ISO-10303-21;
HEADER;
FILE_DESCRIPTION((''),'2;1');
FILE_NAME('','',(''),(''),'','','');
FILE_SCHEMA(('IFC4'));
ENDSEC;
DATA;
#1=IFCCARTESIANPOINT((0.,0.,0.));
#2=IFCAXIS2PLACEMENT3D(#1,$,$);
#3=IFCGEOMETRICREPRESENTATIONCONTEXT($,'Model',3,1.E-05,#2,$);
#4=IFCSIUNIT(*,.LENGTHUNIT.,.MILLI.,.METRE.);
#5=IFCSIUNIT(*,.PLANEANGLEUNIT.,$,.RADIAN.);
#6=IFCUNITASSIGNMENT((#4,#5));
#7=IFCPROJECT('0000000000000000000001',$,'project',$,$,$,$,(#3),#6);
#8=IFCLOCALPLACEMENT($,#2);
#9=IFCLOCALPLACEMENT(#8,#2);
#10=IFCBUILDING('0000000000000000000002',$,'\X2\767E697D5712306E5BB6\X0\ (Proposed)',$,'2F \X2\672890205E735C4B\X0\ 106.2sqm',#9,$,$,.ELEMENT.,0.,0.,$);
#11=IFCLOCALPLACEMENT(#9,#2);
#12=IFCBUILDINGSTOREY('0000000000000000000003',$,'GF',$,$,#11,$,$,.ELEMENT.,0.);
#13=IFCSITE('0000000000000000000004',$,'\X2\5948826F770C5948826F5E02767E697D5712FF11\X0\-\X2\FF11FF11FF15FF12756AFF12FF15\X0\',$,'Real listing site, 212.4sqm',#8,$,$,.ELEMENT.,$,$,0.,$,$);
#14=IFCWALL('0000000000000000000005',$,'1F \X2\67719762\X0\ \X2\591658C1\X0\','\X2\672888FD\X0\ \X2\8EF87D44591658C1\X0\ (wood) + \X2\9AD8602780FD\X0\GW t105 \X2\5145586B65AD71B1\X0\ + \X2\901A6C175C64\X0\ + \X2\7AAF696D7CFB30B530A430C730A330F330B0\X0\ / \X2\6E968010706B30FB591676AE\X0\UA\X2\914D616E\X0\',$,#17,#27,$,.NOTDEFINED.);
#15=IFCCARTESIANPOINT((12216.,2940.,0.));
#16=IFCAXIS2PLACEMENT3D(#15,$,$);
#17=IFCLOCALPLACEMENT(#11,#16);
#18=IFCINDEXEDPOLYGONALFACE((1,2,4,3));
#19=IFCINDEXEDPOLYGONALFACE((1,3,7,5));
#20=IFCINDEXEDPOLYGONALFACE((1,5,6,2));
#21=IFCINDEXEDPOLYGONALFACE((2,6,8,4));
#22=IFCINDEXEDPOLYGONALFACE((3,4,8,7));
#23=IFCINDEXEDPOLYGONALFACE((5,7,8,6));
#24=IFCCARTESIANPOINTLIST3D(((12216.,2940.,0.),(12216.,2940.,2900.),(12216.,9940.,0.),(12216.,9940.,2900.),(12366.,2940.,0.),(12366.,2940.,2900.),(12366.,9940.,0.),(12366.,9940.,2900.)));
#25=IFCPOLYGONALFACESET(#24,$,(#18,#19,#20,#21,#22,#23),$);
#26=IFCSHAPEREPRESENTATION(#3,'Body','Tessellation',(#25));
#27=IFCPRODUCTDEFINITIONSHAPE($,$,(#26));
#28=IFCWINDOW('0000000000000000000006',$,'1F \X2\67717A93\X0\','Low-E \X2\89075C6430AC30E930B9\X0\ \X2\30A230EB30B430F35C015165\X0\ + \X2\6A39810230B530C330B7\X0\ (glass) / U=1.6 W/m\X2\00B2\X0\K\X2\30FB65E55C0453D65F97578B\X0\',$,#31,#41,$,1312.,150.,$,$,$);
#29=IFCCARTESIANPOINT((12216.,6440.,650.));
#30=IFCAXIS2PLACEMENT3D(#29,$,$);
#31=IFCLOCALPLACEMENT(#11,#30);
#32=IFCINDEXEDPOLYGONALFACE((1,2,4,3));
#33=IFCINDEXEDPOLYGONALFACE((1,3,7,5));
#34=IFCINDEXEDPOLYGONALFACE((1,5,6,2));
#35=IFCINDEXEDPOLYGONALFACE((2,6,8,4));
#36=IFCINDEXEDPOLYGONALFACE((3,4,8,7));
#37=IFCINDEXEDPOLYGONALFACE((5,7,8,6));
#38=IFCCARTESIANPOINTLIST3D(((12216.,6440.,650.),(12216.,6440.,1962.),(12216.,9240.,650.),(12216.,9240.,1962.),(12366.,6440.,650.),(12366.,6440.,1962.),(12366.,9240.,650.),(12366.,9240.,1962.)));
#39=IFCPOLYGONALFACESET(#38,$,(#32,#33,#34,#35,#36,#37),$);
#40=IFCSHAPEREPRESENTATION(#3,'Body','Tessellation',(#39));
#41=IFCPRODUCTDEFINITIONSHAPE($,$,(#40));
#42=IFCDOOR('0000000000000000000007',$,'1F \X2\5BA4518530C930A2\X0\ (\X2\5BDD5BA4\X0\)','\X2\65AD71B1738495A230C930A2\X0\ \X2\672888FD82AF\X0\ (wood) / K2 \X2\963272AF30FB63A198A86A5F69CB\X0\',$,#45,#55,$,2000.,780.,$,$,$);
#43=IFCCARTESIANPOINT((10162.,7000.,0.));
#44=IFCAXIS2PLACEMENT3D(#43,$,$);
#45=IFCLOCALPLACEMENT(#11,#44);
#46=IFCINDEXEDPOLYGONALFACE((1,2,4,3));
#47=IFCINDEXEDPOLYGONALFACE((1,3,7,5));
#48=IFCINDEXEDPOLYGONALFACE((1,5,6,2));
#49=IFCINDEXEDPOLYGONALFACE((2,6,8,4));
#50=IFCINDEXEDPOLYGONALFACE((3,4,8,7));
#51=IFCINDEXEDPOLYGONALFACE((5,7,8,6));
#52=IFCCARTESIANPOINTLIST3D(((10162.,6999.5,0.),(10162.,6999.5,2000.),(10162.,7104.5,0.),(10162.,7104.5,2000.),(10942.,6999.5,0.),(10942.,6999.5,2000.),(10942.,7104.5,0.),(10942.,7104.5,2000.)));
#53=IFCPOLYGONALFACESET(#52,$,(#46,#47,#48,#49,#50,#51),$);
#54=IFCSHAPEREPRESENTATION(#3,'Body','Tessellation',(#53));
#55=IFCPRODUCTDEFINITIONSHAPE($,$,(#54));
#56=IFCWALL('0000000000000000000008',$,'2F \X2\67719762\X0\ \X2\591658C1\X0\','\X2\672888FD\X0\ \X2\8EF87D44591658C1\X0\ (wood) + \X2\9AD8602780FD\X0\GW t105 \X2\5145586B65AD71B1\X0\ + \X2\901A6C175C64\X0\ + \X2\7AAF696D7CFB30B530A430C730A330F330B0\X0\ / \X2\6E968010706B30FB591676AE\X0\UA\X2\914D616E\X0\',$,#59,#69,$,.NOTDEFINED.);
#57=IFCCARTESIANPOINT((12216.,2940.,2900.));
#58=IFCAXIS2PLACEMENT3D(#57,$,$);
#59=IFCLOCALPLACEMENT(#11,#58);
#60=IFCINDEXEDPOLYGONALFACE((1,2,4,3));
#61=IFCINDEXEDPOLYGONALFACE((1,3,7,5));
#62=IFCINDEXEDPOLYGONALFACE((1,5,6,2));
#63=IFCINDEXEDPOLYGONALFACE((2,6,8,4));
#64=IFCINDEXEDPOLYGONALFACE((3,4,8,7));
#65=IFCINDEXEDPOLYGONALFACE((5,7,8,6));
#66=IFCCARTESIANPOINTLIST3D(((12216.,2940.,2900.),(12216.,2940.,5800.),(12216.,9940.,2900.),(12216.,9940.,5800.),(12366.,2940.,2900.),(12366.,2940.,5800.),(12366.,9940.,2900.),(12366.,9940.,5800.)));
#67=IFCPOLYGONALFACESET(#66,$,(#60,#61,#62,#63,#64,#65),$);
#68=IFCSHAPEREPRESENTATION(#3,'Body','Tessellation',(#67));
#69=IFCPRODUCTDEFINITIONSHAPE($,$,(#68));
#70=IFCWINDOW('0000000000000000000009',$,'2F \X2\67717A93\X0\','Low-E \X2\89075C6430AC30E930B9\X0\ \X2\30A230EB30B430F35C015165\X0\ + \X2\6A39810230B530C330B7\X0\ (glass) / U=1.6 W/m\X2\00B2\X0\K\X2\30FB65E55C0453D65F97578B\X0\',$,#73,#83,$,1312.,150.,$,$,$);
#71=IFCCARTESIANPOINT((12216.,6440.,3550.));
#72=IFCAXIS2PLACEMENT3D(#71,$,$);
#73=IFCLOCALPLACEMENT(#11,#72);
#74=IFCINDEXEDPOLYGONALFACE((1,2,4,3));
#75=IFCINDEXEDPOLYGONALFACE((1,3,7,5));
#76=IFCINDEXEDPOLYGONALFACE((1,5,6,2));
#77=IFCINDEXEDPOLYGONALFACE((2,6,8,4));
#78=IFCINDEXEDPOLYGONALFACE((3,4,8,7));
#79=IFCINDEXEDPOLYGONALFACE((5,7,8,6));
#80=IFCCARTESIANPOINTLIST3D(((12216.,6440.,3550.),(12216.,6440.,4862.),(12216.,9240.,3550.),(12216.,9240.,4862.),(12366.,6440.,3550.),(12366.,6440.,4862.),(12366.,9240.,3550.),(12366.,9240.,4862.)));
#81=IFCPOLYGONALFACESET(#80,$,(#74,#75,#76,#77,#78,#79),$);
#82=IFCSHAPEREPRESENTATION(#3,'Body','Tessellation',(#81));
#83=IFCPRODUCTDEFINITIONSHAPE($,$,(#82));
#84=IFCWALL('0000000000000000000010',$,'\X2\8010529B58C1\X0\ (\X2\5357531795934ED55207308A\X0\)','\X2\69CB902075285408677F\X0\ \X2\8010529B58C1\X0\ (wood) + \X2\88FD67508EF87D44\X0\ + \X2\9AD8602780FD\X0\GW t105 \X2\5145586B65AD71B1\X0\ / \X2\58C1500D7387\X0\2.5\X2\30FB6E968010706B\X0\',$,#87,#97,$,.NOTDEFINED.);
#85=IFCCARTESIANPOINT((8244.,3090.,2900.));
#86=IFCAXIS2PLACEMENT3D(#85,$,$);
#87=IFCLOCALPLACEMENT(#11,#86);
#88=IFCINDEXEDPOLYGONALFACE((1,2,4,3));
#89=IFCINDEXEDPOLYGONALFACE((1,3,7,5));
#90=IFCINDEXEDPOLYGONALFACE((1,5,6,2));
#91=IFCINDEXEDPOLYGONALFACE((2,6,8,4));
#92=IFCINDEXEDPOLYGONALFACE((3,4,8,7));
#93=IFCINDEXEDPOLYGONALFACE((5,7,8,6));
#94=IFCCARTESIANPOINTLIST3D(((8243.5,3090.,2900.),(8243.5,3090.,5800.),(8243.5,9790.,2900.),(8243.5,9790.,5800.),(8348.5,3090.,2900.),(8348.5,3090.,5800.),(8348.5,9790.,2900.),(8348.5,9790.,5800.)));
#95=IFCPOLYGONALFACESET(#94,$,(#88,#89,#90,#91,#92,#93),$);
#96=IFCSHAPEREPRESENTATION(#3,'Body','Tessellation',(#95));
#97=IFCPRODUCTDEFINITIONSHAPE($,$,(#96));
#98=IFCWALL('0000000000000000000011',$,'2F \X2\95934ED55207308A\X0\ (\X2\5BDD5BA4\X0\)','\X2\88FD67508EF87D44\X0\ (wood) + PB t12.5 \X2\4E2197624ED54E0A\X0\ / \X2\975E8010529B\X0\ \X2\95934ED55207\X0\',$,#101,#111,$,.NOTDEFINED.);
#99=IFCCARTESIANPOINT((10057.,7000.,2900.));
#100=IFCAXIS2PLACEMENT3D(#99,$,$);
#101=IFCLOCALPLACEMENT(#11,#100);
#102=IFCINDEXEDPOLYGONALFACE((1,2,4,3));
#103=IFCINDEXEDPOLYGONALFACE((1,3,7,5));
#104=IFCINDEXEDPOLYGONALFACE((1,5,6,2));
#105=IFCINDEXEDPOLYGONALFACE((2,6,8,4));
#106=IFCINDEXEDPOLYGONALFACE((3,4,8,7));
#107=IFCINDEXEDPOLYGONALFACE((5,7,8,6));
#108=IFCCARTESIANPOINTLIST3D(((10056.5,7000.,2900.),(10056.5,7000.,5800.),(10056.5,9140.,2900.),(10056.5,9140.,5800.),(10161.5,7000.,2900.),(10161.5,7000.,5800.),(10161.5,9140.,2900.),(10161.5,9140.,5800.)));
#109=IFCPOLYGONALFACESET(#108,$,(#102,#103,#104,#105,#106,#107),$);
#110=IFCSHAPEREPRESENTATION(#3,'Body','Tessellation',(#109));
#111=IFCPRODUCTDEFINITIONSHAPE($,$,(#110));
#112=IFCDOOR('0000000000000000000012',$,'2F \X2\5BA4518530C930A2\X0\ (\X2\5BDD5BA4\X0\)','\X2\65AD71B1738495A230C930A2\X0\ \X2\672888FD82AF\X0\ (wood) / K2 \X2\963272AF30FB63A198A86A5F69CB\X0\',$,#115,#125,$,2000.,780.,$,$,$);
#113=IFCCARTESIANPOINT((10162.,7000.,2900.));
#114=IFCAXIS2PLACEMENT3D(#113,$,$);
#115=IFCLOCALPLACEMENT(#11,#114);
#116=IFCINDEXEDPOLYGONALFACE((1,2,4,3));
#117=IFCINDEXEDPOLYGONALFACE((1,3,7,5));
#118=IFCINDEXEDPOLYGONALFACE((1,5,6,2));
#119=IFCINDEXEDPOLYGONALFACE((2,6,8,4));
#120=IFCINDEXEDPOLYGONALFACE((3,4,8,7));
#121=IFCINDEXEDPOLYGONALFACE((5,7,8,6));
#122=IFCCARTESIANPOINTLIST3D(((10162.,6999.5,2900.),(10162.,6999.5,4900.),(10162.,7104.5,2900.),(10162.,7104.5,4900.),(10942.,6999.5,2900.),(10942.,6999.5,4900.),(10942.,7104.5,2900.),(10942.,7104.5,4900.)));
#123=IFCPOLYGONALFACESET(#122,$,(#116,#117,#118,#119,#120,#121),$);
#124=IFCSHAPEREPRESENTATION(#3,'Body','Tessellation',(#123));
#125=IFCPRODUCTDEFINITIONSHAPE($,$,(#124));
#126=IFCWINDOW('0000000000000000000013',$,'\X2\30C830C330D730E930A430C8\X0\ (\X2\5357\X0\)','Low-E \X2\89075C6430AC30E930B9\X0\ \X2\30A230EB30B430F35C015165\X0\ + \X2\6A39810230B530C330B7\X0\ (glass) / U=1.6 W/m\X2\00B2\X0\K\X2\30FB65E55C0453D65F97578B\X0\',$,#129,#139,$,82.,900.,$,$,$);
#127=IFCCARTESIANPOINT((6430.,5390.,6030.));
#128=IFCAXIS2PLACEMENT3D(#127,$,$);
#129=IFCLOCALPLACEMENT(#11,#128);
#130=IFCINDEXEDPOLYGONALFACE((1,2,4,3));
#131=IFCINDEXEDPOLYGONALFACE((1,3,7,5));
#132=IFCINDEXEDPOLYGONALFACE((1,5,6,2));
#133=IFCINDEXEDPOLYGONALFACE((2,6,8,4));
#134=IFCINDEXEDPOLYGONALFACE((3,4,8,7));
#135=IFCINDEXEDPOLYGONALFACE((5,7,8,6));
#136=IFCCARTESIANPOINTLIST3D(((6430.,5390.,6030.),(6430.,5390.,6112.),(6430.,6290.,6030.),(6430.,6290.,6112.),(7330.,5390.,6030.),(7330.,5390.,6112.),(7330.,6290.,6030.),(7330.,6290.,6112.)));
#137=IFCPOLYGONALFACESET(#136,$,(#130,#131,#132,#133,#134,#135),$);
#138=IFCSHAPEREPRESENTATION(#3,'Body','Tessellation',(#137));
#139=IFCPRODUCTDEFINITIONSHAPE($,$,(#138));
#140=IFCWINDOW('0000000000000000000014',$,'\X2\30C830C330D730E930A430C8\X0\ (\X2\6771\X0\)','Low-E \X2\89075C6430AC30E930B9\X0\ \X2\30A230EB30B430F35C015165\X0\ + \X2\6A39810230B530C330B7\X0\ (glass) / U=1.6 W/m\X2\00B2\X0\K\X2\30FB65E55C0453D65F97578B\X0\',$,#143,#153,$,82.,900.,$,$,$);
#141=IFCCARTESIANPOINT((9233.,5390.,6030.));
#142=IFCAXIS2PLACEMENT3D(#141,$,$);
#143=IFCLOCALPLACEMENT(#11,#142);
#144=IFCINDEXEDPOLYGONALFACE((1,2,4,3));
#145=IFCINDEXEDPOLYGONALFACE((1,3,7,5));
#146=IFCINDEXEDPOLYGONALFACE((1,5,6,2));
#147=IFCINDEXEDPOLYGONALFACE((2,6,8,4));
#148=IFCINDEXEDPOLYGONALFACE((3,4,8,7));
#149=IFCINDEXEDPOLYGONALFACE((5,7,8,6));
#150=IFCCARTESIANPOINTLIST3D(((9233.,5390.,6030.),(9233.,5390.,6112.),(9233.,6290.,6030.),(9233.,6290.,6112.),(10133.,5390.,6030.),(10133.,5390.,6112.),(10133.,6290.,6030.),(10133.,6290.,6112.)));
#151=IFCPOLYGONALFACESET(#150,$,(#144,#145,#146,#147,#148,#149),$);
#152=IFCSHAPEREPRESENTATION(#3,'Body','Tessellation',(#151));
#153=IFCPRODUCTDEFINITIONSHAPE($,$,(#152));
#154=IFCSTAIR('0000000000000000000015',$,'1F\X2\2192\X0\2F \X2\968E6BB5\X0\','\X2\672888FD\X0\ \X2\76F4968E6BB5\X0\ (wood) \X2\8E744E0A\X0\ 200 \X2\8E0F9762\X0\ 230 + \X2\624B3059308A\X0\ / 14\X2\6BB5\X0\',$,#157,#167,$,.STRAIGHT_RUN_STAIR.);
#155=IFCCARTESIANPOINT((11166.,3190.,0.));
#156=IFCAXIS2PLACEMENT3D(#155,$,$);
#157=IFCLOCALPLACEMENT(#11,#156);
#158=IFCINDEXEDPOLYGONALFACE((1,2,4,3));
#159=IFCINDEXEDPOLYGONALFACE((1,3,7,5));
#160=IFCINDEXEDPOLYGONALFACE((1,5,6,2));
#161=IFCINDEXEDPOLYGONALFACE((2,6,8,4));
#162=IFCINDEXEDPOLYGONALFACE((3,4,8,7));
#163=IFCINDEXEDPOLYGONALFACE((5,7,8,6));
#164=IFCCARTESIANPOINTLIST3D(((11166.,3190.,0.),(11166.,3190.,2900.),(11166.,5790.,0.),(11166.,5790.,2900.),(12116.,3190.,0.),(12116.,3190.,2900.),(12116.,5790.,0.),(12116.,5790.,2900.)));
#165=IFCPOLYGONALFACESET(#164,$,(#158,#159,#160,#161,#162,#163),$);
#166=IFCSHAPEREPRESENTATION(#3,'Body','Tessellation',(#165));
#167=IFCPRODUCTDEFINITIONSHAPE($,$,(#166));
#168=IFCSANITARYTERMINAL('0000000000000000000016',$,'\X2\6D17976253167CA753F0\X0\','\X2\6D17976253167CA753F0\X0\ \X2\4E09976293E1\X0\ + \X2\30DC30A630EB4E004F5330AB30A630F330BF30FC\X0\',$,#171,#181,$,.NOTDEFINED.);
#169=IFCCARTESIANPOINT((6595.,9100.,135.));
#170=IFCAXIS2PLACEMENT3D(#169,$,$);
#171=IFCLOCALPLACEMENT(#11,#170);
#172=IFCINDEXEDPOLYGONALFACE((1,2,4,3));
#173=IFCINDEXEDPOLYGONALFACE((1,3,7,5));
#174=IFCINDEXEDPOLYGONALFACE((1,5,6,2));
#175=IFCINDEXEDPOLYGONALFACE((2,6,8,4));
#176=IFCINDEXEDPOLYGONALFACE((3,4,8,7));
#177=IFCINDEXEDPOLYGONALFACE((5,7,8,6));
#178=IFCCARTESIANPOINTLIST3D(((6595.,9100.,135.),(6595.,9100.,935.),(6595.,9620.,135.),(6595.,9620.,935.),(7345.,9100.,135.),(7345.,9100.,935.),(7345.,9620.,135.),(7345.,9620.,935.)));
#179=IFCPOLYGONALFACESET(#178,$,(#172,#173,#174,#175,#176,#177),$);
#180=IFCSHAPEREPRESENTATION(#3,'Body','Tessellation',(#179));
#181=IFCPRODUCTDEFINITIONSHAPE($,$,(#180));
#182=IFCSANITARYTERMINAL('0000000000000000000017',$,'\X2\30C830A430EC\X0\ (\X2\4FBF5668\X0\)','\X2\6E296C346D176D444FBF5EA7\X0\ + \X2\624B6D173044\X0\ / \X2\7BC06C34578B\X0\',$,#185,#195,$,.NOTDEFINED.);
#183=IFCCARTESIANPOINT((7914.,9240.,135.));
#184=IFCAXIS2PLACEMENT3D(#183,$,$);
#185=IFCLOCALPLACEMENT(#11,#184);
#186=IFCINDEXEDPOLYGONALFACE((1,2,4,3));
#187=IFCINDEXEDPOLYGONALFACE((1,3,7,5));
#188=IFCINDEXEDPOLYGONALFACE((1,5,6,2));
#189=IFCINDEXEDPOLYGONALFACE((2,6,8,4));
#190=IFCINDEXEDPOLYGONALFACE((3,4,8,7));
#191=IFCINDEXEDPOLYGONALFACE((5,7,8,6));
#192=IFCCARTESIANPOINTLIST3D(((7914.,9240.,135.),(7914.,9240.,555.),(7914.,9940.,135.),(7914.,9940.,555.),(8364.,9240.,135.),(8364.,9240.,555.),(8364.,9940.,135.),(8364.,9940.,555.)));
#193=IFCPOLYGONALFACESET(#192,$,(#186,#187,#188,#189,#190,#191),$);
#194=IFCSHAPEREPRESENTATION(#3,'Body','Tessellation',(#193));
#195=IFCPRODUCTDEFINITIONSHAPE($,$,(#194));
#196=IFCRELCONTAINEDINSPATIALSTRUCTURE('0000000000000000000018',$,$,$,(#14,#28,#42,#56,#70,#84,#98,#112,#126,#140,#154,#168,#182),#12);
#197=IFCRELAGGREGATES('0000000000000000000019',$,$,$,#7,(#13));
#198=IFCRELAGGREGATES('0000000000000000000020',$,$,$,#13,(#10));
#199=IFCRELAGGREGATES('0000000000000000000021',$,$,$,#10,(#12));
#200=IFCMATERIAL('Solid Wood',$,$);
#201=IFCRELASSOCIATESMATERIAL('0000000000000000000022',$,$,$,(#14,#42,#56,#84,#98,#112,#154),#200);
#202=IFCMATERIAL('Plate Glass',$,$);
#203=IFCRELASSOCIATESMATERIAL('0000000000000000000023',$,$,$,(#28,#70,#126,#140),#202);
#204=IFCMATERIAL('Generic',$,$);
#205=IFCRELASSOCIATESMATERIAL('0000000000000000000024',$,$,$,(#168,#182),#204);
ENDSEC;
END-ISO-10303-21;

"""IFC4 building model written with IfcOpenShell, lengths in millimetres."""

from ifc_helpers import new_model, si_unit, frame, frame_2d, origin, place, context, project, spatial, rectangle, extrude, material, element, fill, save


model = new_model("IFC4")

# Units and contexts
model_context = context("Model", 3, precision=1e-05, world=origin())
ifc_project = project(units=[si_unit("LENGTHUNIT", "METRE", prefix="MILLI"), si_unit("PLANEANGLEUNIT", "RADIAN")], contexts=[model_context])

# Site, building, storey
site_placement = place(None, origin())
site = spatial("IfcSite", under=ifc_project, at=site_placement, Name="奈良県奈良市百楽園１-１１５２番２５", ObjectType="Real listing site, 212.4sqm", CompositionType="ELEMENT", RefElevation=0.0)
building_placement = place(site_placement, origin())
building = spatial("IfcBuilding", under=site, at=building_placement, Name="百楽園の家 (Proposed)", ObjectType="2F 木造平屋 106.2sqm", CompositionType="ELEMENT", ElevationOfRefHeight=0.0, ElevationOfTerrain=0.0)
storey_placement = place(building_placement, origin())
storey = spatial("IfcBuildingStorey", under=building, at=storey_placement, Name="GF", CompositionType="ELEMENT", Elevation=0.0)

# Wall, opening, window
ifc_material_1 = material(Name="Solid Wood")
wall_1_placement = place(storey_placement, frame((12216.0, 2940.0, 0.0)))
wall_1 = element("IfcWall", 1, at=wall_1_placement, inside=storey, material=ifc_material_1, Name="1F 東面 外壁", Description="木製 軸組外壁 (wood) + 高性能GW t105 充填断熱 + 通気層 + 窯業系サイディング / 準耐火・外皮UA配慮", PredefinedType="NOTDEFINED", context=model_context, shape_type="SweptSolid", body=[
    extrude(rectangle(XDim=150.0, YDim=7000.0, at=frame_2d((75.0, 3500.0))), frame((12216.0, 2940.0, 0.0)), (0.0, 0.0, 1.0), 2900.0),
])
opening_1_placement = place(storey_placement, frame((12216.0, 6440.0, 650.0)))
opening_1 = element("IfcOpeningElement", 2, at=opening_1_placement, cuts=wall_1, PredefinedType="NOTDEFINED", context=model_context, shape_type="SweptSolid", body=[
    extrude(rectangle(XDim=150.0, YDim=2800.0, at=frame_2d((75.0, 1400.0))), frame((12216.0, 6440.0, 650.0)), (0.0, 0.0, 1.0), 1312.0),
])
ifc_material_2 = material(Name="Plate Glass")
window_1_placement = place(storey_placement, frame((12216.0, 6440.0, 650.0)))
window_1 = element("IfcWindow", 3, at=window_1_placement, inside=storey, material=ifc_material_2, Name="1F 東窓", Description="Low-E 複層ガラス アルゴン封入 + 樹脂サッシ (glass) / U=1.6 W/m²K・日射取得型", OverallHeight=1312.0, OverallWidth=150.0, context=model_context, shape_type="SweptSolid", body=[
    extrude(rectangle(XDim=150.0, YDim=2800.0, at=frame_2d((75.0, 1400.0))), frame((12216.0, 6440.0, 650.0)), (0.0, 0.0, 1.0), 1312.0),
])
fill(opening_1, window_1)

# Door
door_1_placement = place(storey_placement, frame((10162.0, 7000.0, 0.0)))
element("IfcDoor", 4, at=door_1_placement, inside=storey, material=ifc_material_1, Name="1F 室内ドア (寝室)", Description="断熱玄関ドア 木製芯 (wood) / K2 防犯・採風機構", OverallHeight=2000.0, OverallWidth=780.0, context=model_context, shape_type="SweptSolid", body=[
    extrude(rectangle(XDim=780.0, YDim=105.0, at=frame_2d((390.0, 52.0))), frame((10162.0, 7000.0, 0.0)), (0.0, 0.0, 1.0), 2000.0),
])

# Wall, opening, window
wall_2_placement = place(storey_placement, frame((12216.0, 2940.0, 2900.0)))
wall_2 = element("IfcWall", 5, at=wall_2_placement, inside=storey, material=ifc_material_1, Name="2F 東面 外壁", Description="木製 軸組外壁 (wood) + 高性能GW t105 充填断熱 + 通気層 + 窯業系サイディング / 準耐火・外皮UA配慮", PredefinedType="NOTDEFINED", context=model_context, shape_type="SweptSolid", body=[
    extrude(rectangle(XDim=150.0, YDim=7000.0, at=frame_2d((75.0, 3500.0))), frame((12216.0, 2940.0, 2900.0)), (0.0, 0.0, 1.0), 2900.0),
])
opening_2_placement = place(storey_placement, frame((12216.0, 6440.0, 3550.0)))
opening_2 = element("IfcOpeningElement", 6, at=opening_2_placement, cuts=wall_2, PredefinedType="NOTDEFINED", context=model_context, shape_type="SweptSolid", body=[
    extrude(rectangle(XDim=150.0, YDim=2800.0, at=frame_2d((75.0, 1400.0))), frame((12216.0, 6440.0, 3550.0)), (0.0, 0.0, 1.0), 1312.0),
])
window_2_placement = place(storey_placement, frame((12216.0, 6440.0, 3550.0)))
window_2 = element("IfcWindow", 7, at=window_2_placement, inside=storey, material=ifc_material_2, Name="2F 東窓", Description="Low-E 複層ガラス アルゴン封入 + 樹脂サッシ (glass) / U=1.6 W/m²K・日射取得型", OverallHeight=1312.0, OverallWidth=150.0, context=model_context, shape_type="SweptSolid", body=[
    extrude(rectangle(XDim=150.0, YDim=2800.0, at=frame_2d((75.0, 1400.0))), frame((12216.0, 6440.0, 3550.0)), (0.0, 0.0, 1.0), 1312.0),
])
fill(opening_2, window_2)

# Walls
wall_3_placement = place(storey_placement, frame((8244.0, 3090.0, 2900.0)))
element("IfcWall", 8, at=wall_3_placement, inside=storey, material=ifc_material_1, Name="耐力壁 (南北間仕切り)", Description="構造用合板 耐力壁 (wood) + 製材軸組 + 高性能GW t105 充填断熱 / 壁倍率2.5・準耐火", PredefinedType="NOTDEFINED", context=model_context, shape_type="SweptSolid", body=[
    extrude(rectangle(XDim=105.0, YDim=6700.0, at=frame_2d((52.0, 3350.0))), frame((8244.0, 3090.0, 2900.0)), (0.0, 0.0, 1.0), 2900.0),
])
wall_4_placement = place(storey_placement, frame((10057.0, 7000.0, 2900.0)))
element("IfcWall", 9, at=wall_4_placement, inside=storey, material=ifc_material_1, Name="2F 間仕切り (寝室)", Description="製材軸組 (wood) + PB t12.5 両面仕上 / 非耐力 間仕切", PredefinedType="NOTDEFINED", context=model_context, shape_type="SweptSolid", body=[
    extrude(rectangle(XDim=105.0, YDim=2140.0, at=frame_2d((52.0, 1070.0))), frame((10057.0, 7000.0, 2900.0)), (0.0, 0.0, 1.0), 2900.0),
])

# Door
door_2_placement = place(storey_placement, frame((10162.0, 7000.0, 2900.0)))
element("IfcDoor", 10, at=door_2_placement, inside=storey, material=ifc_material_1, Name="2F 室内ドア (寝室)", Description="断熱玄関ドア 木製芯 (wood) / K2 防犯・採風機構", OverallHeight=2000.0, OverallWidth=780.0, context=model_context, shape_type="SweptSolid", body=[
    extrude(rectangle(XDim=780.0, YDim=105.0, at=frame_2d((390.0, 52.0))), frame((10162.0, 7000.0, 2900.0)), (0.0, 0.0, 1.0), 2000.0),
])

# Windows
window_3_placement = place(storey_placement, frame((6430.0, 5390.0, 6030.0)))
element("IfcWindow", 11, at=window_3_placement, inside=storey, material=ifc_material_2, Name="トップライト (南)", Description="Low-E 複層ガラス アルゴン封入 + 樹脂サッシ (glass) / U=1.6 W/m²K・日射取得型", OverallHeight=82.0, OverallWidth=900.0, context=model_context, shape_type="SweptSolid", body=[
    extrude(rectangle(XDim=900.0, YDim=900.0, at=frame_2d((450.0, 450.0))), frame((6430.0, 5390.0, 6030.0)), (0.0, 0.0, 1.0), 82.0),
])
window_4_placement = place(storey_placement, frame((9233.0, 5390.0, 6030.0)))
element("IfcWindow", 12, at=window_4_placement, inside=storey, material=ifc_material_2, Name="トップライト (東)", Description="Low-E 複層ガラス アルゴン封入 + 樹脂サッシ (glass) / U=1.6 W/m²K・日射取得型", OverallHeight=82.0, OverallWidth=900.0, context=model_context, shape_type="SweptSolid", body=[
    extrude(rectangle(XDim=900.0, YDim=900.0, at=frame_2d((450.0, 450.0))), frame((9233.0, 5390.0, 6030.0)), (0.0, 0.0, 1.0), 82.0),
])

# Stair
stair_placement = place(storey_placement, frame((11166.0, 3190.0, 0.0)))
element("IfcStair", 13, at=stair_placement, inside=storey, material=ifc_material_1, Name="1F→2F 階段", Description="木製 直階段 (wood) 蹴上 200 踏面 230 + 手すり / 14段", PredefinedType="STRAIGHT_RUN_STAIR", context=model_context, shape_type="SweptSolid", body=[
    extrude(rectangle(XDim=950.0, YDim=2600.0, at=frame_2d((475.0, 1300.0))), frame((11166.0, 3190.0, 0.0)), (0.0, 0.0, 1.0), 2900.0),
])

# Sanitary terminals
ifc_material_3 = material(Name="Generic")
sanitary_terminal_1_placement = place(storey_placement, frame((6595.0, 9100.0, 135.0)))
element("IfcSanitaryTerminal", 14, at=sanitary_terminal_1_placement, inside=storey, material=ifc_material_3, Name="洗面化粧台", Description="洗面化粧台 三面鏡 + ボウル一体カウンター", PredefinedType="NOTDEFINED", context=model_context, shape_type="SweptSolid", body=[
    extrude(rectangle(XDim=750.0, YDim=520.0, at=frame_2d((375.0, 260.0))), frame((6595.0, 9100.0, 135.0)), (0.0, 0.0, 1.0), 800.0),
])
sanitary_terminal_2_placement = place(storey_placement, frame((7914.0, 9240.0, 135.0)))
element("IfcSanitaryTerminal", 15, at=sanitary_terminal_2_placement, inside=storey, material=ifc_material_3, Name="トイレ (便器)", Description="温水洗浄便座 + 手洗い / 節水型", PredefinedType="NOTDEFINED", context=model_context, shape_type="SweptSolid", body=[
    extrude(rectangle(XDim=450.0, YDim=700.0, at=frame_2d((225.0, 350.0))), frame((7914.0, 9240.0, 135.0)), (0.0, 0.0, 1.0), 420.0),
])

save(model, "model.ifc")
